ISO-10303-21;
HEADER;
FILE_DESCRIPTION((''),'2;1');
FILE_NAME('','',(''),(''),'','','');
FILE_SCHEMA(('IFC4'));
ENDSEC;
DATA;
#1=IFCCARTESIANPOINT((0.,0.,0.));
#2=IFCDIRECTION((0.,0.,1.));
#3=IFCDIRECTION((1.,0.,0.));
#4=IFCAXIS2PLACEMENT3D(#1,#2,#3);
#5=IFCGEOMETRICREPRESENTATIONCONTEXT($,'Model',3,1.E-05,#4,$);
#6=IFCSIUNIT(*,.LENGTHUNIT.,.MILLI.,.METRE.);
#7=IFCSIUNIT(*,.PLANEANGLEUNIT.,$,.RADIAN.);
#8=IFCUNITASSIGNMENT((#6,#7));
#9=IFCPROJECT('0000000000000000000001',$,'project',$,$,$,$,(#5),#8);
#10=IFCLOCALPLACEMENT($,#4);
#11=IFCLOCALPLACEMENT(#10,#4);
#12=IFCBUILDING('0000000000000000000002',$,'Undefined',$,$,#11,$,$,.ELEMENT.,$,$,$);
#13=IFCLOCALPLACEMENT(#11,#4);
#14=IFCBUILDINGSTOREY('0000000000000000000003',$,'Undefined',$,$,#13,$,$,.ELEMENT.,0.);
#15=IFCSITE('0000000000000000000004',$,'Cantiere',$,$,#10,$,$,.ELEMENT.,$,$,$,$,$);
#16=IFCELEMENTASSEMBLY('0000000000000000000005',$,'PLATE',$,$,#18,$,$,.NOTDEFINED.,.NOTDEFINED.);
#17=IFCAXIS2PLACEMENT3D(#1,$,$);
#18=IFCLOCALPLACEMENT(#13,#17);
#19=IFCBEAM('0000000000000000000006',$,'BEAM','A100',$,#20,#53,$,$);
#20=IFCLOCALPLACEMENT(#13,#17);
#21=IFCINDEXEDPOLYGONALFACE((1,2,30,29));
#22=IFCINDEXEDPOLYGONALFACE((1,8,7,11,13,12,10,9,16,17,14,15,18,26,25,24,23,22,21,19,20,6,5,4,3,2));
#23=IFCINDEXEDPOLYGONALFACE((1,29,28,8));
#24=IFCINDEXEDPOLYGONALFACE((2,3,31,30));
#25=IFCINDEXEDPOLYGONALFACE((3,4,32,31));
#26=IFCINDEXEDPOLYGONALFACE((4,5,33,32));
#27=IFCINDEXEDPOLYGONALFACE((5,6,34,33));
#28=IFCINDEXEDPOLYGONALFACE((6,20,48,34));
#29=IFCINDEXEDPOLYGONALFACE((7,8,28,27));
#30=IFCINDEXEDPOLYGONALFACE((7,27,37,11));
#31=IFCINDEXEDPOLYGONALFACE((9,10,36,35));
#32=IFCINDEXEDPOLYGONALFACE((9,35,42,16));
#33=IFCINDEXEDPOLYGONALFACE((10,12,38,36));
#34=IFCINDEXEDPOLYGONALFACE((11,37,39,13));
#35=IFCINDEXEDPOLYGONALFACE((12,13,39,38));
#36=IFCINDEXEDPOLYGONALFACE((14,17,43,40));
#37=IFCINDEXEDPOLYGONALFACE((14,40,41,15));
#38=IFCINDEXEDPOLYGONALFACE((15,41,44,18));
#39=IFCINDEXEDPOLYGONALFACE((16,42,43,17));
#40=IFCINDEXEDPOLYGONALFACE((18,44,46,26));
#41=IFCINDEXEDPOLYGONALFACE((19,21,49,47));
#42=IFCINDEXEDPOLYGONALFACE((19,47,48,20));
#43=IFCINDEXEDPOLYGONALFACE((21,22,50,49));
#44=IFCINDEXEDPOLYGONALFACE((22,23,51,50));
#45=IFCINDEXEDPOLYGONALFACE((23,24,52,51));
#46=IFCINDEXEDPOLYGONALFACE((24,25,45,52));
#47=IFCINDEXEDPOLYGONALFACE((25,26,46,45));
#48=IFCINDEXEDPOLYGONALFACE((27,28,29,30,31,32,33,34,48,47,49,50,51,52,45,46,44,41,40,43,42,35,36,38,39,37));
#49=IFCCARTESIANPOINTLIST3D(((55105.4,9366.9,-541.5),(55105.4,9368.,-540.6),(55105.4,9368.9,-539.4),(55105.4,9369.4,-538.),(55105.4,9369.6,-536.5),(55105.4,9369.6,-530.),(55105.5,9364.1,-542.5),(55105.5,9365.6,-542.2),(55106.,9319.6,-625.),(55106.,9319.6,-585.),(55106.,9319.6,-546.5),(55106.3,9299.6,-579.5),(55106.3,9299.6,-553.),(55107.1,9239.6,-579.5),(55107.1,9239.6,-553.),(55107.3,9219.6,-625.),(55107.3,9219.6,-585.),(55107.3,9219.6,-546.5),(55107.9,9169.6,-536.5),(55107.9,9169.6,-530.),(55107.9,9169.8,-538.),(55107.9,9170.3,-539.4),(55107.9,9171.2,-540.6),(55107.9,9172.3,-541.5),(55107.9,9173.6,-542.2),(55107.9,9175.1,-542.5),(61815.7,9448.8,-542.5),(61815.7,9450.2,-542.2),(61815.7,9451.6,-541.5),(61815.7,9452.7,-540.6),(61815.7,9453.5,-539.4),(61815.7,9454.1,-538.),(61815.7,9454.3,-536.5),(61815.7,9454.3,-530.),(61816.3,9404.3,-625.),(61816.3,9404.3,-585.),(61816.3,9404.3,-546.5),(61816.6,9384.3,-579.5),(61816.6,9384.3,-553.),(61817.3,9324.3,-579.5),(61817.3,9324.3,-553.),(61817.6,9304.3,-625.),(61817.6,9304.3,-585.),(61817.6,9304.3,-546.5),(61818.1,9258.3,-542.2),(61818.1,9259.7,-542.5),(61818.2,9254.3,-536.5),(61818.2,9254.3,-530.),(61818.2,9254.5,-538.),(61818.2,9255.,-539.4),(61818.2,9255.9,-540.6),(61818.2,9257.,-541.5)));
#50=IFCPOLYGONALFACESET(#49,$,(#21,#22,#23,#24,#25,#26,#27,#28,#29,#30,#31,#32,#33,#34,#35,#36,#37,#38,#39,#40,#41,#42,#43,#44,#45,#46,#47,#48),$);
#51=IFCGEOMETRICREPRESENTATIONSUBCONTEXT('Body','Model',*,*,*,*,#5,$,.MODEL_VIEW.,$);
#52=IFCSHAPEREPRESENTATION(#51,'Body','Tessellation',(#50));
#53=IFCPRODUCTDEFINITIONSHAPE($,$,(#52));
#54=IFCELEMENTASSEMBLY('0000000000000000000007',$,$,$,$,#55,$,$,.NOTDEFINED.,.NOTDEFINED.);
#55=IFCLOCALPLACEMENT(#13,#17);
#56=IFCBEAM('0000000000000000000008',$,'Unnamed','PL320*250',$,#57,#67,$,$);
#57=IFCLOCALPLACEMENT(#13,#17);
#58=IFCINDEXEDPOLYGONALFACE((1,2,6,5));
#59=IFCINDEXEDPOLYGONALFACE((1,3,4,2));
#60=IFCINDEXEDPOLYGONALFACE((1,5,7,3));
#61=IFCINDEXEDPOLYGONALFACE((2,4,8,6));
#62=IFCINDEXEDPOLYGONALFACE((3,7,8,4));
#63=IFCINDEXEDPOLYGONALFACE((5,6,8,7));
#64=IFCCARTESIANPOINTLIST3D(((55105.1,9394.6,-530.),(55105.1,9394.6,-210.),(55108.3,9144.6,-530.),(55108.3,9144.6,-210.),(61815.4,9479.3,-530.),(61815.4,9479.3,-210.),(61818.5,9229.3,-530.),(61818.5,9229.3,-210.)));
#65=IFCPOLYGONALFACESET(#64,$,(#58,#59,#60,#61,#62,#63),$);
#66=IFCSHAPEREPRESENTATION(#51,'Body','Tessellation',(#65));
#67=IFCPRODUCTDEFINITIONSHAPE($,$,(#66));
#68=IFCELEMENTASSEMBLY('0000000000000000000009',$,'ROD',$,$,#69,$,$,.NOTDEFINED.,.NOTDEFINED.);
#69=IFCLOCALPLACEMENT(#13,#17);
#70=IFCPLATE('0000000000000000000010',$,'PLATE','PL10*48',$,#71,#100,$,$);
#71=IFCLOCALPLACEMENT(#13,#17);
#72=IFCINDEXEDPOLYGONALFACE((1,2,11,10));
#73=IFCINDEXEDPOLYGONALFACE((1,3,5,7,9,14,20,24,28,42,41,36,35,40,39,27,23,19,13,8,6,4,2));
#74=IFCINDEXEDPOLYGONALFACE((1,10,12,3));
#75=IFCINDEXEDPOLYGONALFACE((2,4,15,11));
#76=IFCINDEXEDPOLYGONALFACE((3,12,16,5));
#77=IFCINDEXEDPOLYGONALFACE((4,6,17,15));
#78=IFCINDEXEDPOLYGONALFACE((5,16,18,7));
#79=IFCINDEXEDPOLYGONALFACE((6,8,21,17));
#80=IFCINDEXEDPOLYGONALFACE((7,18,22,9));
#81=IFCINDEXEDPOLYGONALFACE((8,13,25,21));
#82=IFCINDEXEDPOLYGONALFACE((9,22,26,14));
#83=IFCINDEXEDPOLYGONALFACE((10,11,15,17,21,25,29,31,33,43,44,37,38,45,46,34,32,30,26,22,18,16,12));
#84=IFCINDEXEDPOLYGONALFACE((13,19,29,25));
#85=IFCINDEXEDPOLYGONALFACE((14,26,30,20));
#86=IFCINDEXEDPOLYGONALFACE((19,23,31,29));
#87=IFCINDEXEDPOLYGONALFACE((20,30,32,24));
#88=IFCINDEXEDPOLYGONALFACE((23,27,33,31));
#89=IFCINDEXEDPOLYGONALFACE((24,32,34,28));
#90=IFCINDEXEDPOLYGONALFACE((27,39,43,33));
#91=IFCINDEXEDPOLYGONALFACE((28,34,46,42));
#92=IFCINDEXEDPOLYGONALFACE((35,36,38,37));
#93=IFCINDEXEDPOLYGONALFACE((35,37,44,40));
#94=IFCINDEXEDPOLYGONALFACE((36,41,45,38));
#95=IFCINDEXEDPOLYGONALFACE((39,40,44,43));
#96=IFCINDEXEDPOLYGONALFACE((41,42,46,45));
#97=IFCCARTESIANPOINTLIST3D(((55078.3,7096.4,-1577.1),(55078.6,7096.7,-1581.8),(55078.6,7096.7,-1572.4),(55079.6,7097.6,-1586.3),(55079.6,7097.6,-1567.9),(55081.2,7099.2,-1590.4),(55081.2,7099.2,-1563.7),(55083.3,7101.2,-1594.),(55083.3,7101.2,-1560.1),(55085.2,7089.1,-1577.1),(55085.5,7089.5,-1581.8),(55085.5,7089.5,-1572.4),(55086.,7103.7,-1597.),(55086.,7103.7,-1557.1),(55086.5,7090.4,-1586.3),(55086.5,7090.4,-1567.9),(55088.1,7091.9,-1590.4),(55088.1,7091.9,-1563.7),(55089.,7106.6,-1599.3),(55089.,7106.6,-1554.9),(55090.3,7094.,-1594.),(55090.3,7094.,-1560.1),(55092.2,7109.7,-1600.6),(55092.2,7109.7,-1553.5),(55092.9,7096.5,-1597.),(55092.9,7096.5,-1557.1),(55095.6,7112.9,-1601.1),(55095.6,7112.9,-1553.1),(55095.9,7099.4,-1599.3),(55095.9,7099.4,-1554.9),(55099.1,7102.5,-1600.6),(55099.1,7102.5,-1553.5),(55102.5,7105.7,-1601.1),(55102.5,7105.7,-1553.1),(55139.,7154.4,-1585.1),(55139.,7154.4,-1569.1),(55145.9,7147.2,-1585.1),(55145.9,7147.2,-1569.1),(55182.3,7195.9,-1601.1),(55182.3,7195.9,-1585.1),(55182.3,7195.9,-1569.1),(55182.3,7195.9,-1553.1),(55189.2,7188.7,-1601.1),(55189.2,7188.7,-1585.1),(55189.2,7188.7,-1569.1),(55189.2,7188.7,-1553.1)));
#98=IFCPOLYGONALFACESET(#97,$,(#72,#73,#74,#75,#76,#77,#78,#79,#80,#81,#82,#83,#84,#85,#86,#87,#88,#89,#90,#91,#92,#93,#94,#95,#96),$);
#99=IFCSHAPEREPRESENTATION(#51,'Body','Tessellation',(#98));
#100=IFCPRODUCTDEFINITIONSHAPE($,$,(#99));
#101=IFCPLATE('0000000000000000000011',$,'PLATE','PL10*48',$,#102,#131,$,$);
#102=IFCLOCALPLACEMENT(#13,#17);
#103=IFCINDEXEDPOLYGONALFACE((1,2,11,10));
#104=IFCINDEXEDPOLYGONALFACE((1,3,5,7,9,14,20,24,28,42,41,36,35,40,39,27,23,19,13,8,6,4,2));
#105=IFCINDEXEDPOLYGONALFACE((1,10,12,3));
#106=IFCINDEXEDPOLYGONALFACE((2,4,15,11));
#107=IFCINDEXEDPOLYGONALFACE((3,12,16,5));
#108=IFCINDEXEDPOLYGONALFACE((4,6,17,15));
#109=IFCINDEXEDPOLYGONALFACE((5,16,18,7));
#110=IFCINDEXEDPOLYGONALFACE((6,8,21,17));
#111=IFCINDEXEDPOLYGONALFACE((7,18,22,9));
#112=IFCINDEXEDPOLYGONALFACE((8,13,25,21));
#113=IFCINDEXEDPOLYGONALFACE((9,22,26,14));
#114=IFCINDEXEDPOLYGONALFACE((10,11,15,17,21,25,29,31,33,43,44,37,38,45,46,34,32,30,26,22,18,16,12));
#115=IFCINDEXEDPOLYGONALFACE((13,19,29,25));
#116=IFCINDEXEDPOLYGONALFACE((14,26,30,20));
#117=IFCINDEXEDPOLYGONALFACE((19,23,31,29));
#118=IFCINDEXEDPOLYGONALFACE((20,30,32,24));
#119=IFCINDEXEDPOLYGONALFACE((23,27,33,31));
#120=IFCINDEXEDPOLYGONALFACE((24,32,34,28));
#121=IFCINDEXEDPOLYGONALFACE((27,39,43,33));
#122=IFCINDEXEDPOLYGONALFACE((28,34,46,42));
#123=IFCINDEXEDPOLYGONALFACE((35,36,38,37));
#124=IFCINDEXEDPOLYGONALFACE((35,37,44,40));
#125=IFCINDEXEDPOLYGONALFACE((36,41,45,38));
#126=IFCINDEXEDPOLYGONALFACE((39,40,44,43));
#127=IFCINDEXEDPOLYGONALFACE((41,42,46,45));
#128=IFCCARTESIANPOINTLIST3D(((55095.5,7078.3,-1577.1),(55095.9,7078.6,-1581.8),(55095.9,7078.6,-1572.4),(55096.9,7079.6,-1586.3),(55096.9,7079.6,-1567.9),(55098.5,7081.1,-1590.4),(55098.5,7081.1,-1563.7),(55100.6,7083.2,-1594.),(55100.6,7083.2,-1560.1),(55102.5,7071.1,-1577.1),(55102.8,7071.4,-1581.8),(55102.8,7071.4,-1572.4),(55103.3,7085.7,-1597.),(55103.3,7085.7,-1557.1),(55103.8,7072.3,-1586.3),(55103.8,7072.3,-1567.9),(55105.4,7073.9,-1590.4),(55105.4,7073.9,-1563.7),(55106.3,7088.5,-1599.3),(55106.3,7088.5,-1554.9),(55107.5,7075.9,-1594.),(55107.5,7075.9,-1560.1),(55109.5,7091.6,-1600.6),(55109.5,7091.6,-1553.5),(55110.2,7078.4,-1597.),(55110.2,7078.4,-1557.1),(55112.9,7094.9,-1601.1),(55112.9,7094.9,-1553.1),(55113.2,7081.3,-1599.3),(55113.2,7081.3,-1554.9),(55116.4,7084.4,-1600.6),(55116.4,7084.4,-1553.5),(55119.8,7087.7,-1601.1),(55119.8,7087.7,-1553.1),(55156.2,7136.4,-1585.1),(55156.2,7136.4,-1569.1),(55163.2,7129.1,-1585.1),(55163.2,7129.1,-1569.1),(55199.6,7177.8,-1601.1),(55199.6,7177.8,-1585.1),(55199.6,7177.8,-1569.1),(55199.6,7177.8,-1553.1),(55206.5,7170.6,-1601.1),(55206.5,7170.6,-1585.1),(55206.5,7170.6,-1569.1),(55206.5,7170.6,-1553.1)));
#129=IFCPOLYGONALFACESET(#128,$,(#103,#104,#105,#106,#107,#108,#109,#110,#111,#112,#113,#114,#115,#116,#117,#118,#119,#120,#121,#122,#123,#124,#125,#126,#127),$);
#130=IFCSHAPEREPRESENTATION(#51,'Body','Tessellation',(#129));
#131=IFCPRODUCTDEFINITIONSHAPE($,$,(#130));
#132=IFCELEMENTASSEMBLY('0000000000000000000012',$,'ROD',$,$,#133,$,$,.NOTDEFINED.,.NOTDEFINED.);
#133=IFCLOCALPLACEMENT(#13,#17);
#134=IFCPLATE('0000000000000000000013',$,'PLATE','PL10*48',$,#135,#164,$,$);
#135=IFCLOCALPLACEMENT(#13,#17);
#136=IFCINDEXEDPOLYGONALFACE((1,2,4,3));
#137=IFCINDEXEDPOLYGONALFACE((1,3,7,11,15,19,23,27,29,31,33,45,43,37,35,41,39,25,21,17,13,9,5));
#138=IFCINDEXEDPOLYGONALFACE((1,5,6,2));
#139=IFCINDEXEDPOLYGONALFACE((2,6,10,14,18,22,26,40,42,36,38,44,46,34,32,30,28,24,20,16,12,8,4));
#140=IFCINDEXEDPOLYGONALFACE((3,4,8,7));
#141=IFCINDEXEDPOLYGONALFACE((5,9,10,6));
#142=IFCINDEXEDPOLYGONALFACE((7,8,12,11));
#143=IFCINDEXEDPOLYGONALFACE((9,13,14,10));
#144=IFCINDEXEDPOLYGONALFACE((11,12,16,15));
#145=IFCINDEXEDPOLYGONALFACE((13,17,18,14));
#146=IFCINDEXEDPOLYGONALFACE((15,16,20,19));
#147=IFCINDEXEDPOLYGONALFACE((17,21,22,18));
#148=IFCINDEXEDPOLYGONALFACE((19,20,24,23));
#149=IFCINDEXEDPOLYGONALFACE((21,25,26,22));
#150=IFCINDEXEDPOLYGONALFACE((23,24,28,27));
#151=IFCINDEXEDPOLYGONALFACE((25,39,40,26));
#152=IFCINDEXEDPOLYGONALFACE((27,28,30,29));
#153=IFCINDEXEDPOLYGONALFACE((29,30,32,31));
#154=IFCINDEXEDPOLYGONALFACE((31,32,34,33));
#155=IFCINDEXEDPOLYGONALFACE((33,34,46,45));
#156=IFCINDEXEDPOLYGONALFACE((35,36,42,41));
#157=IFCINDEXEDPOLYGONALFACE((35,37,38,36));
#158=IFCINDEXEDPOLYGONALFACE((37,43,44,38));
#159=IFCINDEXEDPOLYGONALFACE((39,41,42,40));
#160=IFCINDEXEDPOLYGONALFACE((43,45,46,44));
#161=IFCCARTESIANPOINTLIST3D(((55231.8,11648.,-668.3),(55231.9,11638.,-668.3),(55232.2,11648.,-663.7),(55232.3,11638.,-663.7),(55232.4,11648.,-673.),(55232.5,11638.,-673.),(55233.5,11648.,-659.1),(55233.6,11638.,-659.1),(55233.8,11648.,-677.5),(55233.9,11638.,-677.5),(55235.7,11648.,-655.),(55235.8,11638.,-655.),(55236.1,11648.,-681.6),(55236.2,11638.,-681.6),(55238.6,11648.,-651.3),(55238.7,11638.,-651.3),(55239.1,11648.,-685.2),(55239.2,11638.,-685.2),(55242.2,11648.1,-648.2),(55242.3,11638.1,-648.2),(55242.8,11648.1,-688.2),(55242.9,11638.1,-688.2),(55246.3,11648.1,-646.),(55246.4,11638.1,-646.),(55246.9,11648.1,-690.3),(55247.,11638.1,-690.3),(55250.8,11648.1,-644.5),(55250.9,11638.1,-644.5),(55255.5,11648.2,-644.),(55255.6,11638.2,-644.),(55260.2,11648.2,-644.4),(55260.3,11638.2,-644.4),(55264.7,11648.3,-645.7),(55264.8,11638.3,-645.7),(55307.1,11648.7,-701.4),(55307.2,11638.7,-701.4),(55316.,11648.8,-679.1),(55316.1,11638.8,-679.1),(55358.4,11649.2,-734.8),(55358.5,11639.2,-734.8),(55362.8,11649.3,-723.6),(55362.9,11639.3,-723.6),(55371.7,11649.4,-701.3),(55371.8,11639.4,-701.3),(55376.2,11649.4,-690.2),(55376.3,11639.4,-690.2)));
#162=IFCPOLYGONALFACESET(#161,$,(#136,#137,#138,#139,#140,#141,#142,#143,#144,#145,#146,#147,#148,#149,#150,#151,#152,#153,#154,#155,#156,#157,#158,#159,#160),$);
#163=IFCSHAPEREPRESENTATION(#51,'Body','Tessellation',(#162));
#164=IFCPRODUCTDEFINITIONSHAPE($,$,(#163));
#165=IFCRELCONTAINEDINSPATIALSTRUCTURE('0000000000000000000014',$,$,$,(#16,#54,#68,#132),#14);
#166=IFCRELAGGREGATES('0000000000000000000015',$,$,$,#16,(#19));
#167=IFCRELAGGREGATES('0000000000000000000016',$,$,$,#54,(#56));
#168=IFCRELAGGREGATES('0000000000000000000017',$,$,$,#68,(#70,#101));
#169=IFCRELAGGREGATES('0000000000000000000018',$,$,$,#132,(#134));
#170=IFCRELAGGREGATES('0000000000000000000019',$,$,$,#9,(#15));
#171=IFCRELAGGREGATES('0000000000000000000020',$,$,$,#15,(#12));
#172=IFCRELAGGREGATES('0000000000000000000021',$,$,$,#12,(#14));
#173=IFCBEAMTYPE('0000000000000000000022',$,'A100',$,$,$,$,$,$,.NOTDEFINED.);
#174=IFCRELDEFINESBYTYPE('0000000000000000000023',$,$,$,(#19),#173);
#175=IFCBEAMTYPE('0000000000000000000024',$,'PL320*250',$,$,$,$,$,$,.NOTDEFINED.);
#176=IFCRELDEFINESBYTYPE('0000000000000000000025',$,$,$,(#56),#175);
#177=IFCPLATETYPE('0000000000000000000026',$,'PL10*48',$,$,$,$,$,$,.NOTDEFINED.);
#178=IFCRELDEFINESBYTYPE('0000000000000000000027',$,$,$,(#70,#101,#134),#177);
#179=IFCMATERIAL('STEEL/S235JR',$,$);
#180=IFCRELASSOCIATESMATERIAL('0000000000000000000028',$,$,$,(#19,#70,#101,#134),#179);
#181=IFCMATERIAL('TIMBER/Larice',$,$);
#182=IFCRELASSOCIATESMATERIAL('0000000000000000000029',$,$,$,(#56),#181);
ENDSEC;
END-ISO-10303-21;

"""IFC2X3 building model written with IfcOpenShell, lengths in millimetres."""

from ifc_helpers import new_model, si_unit, frame, origin_with_axes, origin_2d_with_axis, place, context, subcontext, project, spatial, polyline, rectangle, outline, extrude, material, type_object, element, aggregate, save


model = new_model("IFC2X3")

# Units and contexts
model_context = context("Model", 3, precision=1e-05, world=origin_with_axes())
body_context = subcontext(model_context, "Body", "Model", "MODEL_VIEW")
ifc_project = project(units=[si_unit("LENGTHUNIT", "METRE", prefix="MILLI"), si_unit("PLANEANGLEUNIT", "RADIAN")], contexts=[model_context])

# Site, building, storey
site_placement = place(None, origin_with_axes())
site = spatial("IfcSite", under=ifc_project, at=site_placement, Name="Cantiere", CompositionType="ELEMENT")
building_placement = place(site_placement, origin_with_axes())
building = spatial("IfcBuilding", under=site, at=building_placement, Name="Undefined", CompositionType="ELEMENT")
storey_placement = place(building_placement, origin_with_axes())
storey = spatial("IfcBuildingStorey", under=building, at=storey_placement, Name="Undefined", CompositionType="ELEMENT", Elevation=0.0)

# Element assemblies, beams
assembly_1_placement = place(storey_placement, origin_with_axes())
assembly_1 = element("IfcElementAssembly", 1, at=assembly_1_placement, inside=storey, Name="PLATE", AssemblyPlace="NOTDEFINED", PredefinedType="NOTDEFINED")
ifc_material_1 = material(Name="STEEL/S235JR")
beam_type_1 = type_object("IfcBeamType", Name="A100", PredefinedType="NOTDEFINED")
beam_1_placement = place(assembly_1_placement, frame((55106.7, 9269.6, -577.5), z_axis=(0.0, 0.000001, -1.0), x_axis=(0.99992, 0.012617, 0.0)))
beam_1 = element("IfcBeam", 2, at=beam_1_placement, type_object=beam_type_1, material=ifc_material_1, Name="BEAM", Description="A100", context=body_context, shape_type="SweptSolid", body=[
    extrude(outline(polyline([(30.0, -24.5), (50.0, -31.0), (94.5, -35.0), (96.0, -35.3), (97.3, -36.0), (98.4, -36.9), (99.3, -38.1), (99.8, -39.5), (100.0, -41.0), (100.0, -47.5), (-100.0, -47.5), (-100.0, -41.0), (-99.8, -39.5), (-99.3, -38.1), (-98.4, -36.9), (-97.3, -36.0), (-96.0, -35.3), (-94.5, -35.0), (-50.0, -31.0), (-30.0, -24.5), (-30.0, 2.0), (-50.0, 7.5), (-50.0, 47.5), (50.0, 47.5), (50.0, 7.5), (30.0, 2.0), (30.0, -24.5)])), frame((6710.8, 0.0, 0.0), z_axis=(-1.0, 0.0, 0.0), x_axis=(0.0, -1.0, 0.0)), (0.0, 0.0, 1.0), 6710.8),
])
aggregate(assembly_1, [beam_1])
assembly_2_placement = place(storey_placement, origin_with_axes())
assembly_2 = element("IfcElementAssembly", 3, at=assembly_2_placement, inside=storey, AssemblyPlace="NOTDEFINED", PredefinedType="NOTDEFINED")
ifc_material_2 = material(Name="TIMBER/Larice")
beam_type_2 = type_object("IfcBeamType", Name="PL320*250", PredefinedType="NOTDEFINED")
beam_2_placement = place(assembly_2_placement, frame((55106.7, 9269.6, -370.0), z_axis=(0.0, 0.0, 1.0), x_axis=(0.99992, 0.012617, 0.0)))
beam_2 = element("IfcBeam", 4, at=beam_2_placement, type_object=beam_type_2, material=ifc_material_2, Name="Unnamed", Description="PL320*250", context=body_context, shape_type="SweptSolid", body=[
    extrude(rectangle(XDim=250.0, YDim=320.0, at=origin_2d_with_axis()), frame((6710.8, 0.0, 0.0), z_axis=(-1.0, 0.0, 0.0), x_axis=(0.0, -1.0, 0.0)), (0.0, 0.0, 1.0), 6710.8),
])
aggregate(assembly_2, [beam_2])

# Element assemblies, plates
assembly_3_placement = place(storey_placement, origin_with_axes())
assembly_3 = element("IfcElementAssembly", 5, at=assembly_3_placement, inside=storey, Name="ROD", AssemblyPlace="NOTDEFINED", PredefinedType="NOTDEFINED")
plate_type_1 = type_object("IfcPlateType", Name="PL10*48", PredefinedType="NOTDEFINED")
plate_1_placement = place(assembly_3_placement, frame((55185.8, 7192.3, -1601.1), z_axis=(-0.69134, 0.72253, 0.0), x_axis=(-0.72253, -0.69134, 0.0)))
plate_1 = element("IfcPlate", 6, at=plate_1_placement, type_object=plate_type_1, material=ifc_material_1, Name="PLATE", Description="PL10*48", context=body_context, shape_type="SweptSolid", body=[
    extrude(outline(polyline([(0.0, 0.0), (120.0, 0.0), (124.7, 0.5), (129.2, 1.8), (133.3, 4.0), (137.0, 7.0), (140.0, 10.7), (142.2, 14.8), (143.5, 19.3), (144.0, 24.0), (144.0, 24.0), (143.5, 28.7), (142.2, 33.2), (140.0, 37.3), (137.0, 41.0), (133.3, 44.0), (129.2, 46.2), (124.7, 47.5), (120.0, 48.0), (0.0, 48.0), (0.0, 32.0), (60.0, 32.0), (60.0, 16.0), (0.0, 16.0), (0.0, 0.0)])), frame((0.0, 0.0, -5.0), z_axis=(0.0, 0.0, 1.0), x_axis=(1.0, 0.0, 0.0)), (0.0, 0.0, 1.0), 10.0),
])
plate_2_placement = place(assembly_3_placement, frame((55203.0, 7174.2, -1601.1), z_axis=(-0.69134, 0.72253, 0.0), x_axis=(-0.72253, -0.69134, 0.0)))
plate_2 = element("IfcPlate", 7, at=plate_2_placement, type_object=plate_type_1, material=ifc_material_1, Name="PLATE", Description="PL10*48", context=body_context, shape_type="SweptSolid", body=[
    extrude(outline(polyline([(0.0, 0.0), (120.0, 0.0), (124.7, 0.5), (129.2, 1.8), (133.3, 4.0), (137.0, 7.0), (140.0, 10.7), (142.2, 14.8), (143.5, 19.3), (144.0, 24.0), (144.0, 24.0), (143.5, 28.7), (142.2, 33.2), (140.0, 37.3), (137.0, 41.0), (133.3, 44.0), (129.2, 46.2), (124.7, 47.5), (120.0, 48.0), (0.0, 48.0), (0.0, 32.0), (60.0, 32.0), (60.0, 16.0), (0.0, 16.0), (0.0, 0.0)])), frame((0.0, 0.0, -5.0), z_axis=(0.0, 0.0, 1.0), x_axis=(1.0, 0.0, 0.0)), (0.0, 0.0, 1.0), 10.0),
])
assembly_4_placement = place(storey_placement, origin_with_axes())
assembly_4 = element("IfcElementAssembly", 8, at=assembly_4_placement, inside=storey, Name="ROD", AssemblyPlace="NOTDEFINED", PredefinedType="NOTDEFINED")
plate_3_placement = place(assembly_4_placement, frame((55376.2, 11644.4, -690.2), z_axis=(0.009999, -0.99995, 0.0), x_axis=(-0.928849, -0.009288, 0.370341)))
plate_3 = element("IfcPlate", 9, at=plate_3_placement, type_object=plate_type_1, material=ifc_material_1, Name="PLATE", Description="PL10*48", context=body_context, shape_type="SweptSolid", body=[
    extrude(outline(polyline([(0.0, 0.0), (120.0, 0.0), (124.7, 0.5), (129.2, 1.8), (133.3, 4.0), (137.0, 7.0), (140.0, 10.7), (142.2, 14.8), (143.5, 19.3), (144.0, 24.0), (144.0, 24.0), (143.5, 28.7), (142.2, 33.2), (140.0, 37.3), (137.0, 41.0), (133.3, 44.0), (129.2, 46.2), (124.7, 47.5), (120.0, 48.0), (0.0, 48.0), (0.0, 36.0), (60.0, 36.0), (60.0, 12.0), (0.0, 12.0), (0.0, 0.0)])), frame((0.0, 0.0, -5.0), z_axis=(0.0, 0.0, 1.0), x_axis=(1.0, 0.0, 0.0)), (0.0, 0.0, 1.0), 10.0),
])

aggregate(assembly_3, [plate_1, plate_2])
aggregate(assembly_4, [plate_3])

save(model, "model.ifc")
